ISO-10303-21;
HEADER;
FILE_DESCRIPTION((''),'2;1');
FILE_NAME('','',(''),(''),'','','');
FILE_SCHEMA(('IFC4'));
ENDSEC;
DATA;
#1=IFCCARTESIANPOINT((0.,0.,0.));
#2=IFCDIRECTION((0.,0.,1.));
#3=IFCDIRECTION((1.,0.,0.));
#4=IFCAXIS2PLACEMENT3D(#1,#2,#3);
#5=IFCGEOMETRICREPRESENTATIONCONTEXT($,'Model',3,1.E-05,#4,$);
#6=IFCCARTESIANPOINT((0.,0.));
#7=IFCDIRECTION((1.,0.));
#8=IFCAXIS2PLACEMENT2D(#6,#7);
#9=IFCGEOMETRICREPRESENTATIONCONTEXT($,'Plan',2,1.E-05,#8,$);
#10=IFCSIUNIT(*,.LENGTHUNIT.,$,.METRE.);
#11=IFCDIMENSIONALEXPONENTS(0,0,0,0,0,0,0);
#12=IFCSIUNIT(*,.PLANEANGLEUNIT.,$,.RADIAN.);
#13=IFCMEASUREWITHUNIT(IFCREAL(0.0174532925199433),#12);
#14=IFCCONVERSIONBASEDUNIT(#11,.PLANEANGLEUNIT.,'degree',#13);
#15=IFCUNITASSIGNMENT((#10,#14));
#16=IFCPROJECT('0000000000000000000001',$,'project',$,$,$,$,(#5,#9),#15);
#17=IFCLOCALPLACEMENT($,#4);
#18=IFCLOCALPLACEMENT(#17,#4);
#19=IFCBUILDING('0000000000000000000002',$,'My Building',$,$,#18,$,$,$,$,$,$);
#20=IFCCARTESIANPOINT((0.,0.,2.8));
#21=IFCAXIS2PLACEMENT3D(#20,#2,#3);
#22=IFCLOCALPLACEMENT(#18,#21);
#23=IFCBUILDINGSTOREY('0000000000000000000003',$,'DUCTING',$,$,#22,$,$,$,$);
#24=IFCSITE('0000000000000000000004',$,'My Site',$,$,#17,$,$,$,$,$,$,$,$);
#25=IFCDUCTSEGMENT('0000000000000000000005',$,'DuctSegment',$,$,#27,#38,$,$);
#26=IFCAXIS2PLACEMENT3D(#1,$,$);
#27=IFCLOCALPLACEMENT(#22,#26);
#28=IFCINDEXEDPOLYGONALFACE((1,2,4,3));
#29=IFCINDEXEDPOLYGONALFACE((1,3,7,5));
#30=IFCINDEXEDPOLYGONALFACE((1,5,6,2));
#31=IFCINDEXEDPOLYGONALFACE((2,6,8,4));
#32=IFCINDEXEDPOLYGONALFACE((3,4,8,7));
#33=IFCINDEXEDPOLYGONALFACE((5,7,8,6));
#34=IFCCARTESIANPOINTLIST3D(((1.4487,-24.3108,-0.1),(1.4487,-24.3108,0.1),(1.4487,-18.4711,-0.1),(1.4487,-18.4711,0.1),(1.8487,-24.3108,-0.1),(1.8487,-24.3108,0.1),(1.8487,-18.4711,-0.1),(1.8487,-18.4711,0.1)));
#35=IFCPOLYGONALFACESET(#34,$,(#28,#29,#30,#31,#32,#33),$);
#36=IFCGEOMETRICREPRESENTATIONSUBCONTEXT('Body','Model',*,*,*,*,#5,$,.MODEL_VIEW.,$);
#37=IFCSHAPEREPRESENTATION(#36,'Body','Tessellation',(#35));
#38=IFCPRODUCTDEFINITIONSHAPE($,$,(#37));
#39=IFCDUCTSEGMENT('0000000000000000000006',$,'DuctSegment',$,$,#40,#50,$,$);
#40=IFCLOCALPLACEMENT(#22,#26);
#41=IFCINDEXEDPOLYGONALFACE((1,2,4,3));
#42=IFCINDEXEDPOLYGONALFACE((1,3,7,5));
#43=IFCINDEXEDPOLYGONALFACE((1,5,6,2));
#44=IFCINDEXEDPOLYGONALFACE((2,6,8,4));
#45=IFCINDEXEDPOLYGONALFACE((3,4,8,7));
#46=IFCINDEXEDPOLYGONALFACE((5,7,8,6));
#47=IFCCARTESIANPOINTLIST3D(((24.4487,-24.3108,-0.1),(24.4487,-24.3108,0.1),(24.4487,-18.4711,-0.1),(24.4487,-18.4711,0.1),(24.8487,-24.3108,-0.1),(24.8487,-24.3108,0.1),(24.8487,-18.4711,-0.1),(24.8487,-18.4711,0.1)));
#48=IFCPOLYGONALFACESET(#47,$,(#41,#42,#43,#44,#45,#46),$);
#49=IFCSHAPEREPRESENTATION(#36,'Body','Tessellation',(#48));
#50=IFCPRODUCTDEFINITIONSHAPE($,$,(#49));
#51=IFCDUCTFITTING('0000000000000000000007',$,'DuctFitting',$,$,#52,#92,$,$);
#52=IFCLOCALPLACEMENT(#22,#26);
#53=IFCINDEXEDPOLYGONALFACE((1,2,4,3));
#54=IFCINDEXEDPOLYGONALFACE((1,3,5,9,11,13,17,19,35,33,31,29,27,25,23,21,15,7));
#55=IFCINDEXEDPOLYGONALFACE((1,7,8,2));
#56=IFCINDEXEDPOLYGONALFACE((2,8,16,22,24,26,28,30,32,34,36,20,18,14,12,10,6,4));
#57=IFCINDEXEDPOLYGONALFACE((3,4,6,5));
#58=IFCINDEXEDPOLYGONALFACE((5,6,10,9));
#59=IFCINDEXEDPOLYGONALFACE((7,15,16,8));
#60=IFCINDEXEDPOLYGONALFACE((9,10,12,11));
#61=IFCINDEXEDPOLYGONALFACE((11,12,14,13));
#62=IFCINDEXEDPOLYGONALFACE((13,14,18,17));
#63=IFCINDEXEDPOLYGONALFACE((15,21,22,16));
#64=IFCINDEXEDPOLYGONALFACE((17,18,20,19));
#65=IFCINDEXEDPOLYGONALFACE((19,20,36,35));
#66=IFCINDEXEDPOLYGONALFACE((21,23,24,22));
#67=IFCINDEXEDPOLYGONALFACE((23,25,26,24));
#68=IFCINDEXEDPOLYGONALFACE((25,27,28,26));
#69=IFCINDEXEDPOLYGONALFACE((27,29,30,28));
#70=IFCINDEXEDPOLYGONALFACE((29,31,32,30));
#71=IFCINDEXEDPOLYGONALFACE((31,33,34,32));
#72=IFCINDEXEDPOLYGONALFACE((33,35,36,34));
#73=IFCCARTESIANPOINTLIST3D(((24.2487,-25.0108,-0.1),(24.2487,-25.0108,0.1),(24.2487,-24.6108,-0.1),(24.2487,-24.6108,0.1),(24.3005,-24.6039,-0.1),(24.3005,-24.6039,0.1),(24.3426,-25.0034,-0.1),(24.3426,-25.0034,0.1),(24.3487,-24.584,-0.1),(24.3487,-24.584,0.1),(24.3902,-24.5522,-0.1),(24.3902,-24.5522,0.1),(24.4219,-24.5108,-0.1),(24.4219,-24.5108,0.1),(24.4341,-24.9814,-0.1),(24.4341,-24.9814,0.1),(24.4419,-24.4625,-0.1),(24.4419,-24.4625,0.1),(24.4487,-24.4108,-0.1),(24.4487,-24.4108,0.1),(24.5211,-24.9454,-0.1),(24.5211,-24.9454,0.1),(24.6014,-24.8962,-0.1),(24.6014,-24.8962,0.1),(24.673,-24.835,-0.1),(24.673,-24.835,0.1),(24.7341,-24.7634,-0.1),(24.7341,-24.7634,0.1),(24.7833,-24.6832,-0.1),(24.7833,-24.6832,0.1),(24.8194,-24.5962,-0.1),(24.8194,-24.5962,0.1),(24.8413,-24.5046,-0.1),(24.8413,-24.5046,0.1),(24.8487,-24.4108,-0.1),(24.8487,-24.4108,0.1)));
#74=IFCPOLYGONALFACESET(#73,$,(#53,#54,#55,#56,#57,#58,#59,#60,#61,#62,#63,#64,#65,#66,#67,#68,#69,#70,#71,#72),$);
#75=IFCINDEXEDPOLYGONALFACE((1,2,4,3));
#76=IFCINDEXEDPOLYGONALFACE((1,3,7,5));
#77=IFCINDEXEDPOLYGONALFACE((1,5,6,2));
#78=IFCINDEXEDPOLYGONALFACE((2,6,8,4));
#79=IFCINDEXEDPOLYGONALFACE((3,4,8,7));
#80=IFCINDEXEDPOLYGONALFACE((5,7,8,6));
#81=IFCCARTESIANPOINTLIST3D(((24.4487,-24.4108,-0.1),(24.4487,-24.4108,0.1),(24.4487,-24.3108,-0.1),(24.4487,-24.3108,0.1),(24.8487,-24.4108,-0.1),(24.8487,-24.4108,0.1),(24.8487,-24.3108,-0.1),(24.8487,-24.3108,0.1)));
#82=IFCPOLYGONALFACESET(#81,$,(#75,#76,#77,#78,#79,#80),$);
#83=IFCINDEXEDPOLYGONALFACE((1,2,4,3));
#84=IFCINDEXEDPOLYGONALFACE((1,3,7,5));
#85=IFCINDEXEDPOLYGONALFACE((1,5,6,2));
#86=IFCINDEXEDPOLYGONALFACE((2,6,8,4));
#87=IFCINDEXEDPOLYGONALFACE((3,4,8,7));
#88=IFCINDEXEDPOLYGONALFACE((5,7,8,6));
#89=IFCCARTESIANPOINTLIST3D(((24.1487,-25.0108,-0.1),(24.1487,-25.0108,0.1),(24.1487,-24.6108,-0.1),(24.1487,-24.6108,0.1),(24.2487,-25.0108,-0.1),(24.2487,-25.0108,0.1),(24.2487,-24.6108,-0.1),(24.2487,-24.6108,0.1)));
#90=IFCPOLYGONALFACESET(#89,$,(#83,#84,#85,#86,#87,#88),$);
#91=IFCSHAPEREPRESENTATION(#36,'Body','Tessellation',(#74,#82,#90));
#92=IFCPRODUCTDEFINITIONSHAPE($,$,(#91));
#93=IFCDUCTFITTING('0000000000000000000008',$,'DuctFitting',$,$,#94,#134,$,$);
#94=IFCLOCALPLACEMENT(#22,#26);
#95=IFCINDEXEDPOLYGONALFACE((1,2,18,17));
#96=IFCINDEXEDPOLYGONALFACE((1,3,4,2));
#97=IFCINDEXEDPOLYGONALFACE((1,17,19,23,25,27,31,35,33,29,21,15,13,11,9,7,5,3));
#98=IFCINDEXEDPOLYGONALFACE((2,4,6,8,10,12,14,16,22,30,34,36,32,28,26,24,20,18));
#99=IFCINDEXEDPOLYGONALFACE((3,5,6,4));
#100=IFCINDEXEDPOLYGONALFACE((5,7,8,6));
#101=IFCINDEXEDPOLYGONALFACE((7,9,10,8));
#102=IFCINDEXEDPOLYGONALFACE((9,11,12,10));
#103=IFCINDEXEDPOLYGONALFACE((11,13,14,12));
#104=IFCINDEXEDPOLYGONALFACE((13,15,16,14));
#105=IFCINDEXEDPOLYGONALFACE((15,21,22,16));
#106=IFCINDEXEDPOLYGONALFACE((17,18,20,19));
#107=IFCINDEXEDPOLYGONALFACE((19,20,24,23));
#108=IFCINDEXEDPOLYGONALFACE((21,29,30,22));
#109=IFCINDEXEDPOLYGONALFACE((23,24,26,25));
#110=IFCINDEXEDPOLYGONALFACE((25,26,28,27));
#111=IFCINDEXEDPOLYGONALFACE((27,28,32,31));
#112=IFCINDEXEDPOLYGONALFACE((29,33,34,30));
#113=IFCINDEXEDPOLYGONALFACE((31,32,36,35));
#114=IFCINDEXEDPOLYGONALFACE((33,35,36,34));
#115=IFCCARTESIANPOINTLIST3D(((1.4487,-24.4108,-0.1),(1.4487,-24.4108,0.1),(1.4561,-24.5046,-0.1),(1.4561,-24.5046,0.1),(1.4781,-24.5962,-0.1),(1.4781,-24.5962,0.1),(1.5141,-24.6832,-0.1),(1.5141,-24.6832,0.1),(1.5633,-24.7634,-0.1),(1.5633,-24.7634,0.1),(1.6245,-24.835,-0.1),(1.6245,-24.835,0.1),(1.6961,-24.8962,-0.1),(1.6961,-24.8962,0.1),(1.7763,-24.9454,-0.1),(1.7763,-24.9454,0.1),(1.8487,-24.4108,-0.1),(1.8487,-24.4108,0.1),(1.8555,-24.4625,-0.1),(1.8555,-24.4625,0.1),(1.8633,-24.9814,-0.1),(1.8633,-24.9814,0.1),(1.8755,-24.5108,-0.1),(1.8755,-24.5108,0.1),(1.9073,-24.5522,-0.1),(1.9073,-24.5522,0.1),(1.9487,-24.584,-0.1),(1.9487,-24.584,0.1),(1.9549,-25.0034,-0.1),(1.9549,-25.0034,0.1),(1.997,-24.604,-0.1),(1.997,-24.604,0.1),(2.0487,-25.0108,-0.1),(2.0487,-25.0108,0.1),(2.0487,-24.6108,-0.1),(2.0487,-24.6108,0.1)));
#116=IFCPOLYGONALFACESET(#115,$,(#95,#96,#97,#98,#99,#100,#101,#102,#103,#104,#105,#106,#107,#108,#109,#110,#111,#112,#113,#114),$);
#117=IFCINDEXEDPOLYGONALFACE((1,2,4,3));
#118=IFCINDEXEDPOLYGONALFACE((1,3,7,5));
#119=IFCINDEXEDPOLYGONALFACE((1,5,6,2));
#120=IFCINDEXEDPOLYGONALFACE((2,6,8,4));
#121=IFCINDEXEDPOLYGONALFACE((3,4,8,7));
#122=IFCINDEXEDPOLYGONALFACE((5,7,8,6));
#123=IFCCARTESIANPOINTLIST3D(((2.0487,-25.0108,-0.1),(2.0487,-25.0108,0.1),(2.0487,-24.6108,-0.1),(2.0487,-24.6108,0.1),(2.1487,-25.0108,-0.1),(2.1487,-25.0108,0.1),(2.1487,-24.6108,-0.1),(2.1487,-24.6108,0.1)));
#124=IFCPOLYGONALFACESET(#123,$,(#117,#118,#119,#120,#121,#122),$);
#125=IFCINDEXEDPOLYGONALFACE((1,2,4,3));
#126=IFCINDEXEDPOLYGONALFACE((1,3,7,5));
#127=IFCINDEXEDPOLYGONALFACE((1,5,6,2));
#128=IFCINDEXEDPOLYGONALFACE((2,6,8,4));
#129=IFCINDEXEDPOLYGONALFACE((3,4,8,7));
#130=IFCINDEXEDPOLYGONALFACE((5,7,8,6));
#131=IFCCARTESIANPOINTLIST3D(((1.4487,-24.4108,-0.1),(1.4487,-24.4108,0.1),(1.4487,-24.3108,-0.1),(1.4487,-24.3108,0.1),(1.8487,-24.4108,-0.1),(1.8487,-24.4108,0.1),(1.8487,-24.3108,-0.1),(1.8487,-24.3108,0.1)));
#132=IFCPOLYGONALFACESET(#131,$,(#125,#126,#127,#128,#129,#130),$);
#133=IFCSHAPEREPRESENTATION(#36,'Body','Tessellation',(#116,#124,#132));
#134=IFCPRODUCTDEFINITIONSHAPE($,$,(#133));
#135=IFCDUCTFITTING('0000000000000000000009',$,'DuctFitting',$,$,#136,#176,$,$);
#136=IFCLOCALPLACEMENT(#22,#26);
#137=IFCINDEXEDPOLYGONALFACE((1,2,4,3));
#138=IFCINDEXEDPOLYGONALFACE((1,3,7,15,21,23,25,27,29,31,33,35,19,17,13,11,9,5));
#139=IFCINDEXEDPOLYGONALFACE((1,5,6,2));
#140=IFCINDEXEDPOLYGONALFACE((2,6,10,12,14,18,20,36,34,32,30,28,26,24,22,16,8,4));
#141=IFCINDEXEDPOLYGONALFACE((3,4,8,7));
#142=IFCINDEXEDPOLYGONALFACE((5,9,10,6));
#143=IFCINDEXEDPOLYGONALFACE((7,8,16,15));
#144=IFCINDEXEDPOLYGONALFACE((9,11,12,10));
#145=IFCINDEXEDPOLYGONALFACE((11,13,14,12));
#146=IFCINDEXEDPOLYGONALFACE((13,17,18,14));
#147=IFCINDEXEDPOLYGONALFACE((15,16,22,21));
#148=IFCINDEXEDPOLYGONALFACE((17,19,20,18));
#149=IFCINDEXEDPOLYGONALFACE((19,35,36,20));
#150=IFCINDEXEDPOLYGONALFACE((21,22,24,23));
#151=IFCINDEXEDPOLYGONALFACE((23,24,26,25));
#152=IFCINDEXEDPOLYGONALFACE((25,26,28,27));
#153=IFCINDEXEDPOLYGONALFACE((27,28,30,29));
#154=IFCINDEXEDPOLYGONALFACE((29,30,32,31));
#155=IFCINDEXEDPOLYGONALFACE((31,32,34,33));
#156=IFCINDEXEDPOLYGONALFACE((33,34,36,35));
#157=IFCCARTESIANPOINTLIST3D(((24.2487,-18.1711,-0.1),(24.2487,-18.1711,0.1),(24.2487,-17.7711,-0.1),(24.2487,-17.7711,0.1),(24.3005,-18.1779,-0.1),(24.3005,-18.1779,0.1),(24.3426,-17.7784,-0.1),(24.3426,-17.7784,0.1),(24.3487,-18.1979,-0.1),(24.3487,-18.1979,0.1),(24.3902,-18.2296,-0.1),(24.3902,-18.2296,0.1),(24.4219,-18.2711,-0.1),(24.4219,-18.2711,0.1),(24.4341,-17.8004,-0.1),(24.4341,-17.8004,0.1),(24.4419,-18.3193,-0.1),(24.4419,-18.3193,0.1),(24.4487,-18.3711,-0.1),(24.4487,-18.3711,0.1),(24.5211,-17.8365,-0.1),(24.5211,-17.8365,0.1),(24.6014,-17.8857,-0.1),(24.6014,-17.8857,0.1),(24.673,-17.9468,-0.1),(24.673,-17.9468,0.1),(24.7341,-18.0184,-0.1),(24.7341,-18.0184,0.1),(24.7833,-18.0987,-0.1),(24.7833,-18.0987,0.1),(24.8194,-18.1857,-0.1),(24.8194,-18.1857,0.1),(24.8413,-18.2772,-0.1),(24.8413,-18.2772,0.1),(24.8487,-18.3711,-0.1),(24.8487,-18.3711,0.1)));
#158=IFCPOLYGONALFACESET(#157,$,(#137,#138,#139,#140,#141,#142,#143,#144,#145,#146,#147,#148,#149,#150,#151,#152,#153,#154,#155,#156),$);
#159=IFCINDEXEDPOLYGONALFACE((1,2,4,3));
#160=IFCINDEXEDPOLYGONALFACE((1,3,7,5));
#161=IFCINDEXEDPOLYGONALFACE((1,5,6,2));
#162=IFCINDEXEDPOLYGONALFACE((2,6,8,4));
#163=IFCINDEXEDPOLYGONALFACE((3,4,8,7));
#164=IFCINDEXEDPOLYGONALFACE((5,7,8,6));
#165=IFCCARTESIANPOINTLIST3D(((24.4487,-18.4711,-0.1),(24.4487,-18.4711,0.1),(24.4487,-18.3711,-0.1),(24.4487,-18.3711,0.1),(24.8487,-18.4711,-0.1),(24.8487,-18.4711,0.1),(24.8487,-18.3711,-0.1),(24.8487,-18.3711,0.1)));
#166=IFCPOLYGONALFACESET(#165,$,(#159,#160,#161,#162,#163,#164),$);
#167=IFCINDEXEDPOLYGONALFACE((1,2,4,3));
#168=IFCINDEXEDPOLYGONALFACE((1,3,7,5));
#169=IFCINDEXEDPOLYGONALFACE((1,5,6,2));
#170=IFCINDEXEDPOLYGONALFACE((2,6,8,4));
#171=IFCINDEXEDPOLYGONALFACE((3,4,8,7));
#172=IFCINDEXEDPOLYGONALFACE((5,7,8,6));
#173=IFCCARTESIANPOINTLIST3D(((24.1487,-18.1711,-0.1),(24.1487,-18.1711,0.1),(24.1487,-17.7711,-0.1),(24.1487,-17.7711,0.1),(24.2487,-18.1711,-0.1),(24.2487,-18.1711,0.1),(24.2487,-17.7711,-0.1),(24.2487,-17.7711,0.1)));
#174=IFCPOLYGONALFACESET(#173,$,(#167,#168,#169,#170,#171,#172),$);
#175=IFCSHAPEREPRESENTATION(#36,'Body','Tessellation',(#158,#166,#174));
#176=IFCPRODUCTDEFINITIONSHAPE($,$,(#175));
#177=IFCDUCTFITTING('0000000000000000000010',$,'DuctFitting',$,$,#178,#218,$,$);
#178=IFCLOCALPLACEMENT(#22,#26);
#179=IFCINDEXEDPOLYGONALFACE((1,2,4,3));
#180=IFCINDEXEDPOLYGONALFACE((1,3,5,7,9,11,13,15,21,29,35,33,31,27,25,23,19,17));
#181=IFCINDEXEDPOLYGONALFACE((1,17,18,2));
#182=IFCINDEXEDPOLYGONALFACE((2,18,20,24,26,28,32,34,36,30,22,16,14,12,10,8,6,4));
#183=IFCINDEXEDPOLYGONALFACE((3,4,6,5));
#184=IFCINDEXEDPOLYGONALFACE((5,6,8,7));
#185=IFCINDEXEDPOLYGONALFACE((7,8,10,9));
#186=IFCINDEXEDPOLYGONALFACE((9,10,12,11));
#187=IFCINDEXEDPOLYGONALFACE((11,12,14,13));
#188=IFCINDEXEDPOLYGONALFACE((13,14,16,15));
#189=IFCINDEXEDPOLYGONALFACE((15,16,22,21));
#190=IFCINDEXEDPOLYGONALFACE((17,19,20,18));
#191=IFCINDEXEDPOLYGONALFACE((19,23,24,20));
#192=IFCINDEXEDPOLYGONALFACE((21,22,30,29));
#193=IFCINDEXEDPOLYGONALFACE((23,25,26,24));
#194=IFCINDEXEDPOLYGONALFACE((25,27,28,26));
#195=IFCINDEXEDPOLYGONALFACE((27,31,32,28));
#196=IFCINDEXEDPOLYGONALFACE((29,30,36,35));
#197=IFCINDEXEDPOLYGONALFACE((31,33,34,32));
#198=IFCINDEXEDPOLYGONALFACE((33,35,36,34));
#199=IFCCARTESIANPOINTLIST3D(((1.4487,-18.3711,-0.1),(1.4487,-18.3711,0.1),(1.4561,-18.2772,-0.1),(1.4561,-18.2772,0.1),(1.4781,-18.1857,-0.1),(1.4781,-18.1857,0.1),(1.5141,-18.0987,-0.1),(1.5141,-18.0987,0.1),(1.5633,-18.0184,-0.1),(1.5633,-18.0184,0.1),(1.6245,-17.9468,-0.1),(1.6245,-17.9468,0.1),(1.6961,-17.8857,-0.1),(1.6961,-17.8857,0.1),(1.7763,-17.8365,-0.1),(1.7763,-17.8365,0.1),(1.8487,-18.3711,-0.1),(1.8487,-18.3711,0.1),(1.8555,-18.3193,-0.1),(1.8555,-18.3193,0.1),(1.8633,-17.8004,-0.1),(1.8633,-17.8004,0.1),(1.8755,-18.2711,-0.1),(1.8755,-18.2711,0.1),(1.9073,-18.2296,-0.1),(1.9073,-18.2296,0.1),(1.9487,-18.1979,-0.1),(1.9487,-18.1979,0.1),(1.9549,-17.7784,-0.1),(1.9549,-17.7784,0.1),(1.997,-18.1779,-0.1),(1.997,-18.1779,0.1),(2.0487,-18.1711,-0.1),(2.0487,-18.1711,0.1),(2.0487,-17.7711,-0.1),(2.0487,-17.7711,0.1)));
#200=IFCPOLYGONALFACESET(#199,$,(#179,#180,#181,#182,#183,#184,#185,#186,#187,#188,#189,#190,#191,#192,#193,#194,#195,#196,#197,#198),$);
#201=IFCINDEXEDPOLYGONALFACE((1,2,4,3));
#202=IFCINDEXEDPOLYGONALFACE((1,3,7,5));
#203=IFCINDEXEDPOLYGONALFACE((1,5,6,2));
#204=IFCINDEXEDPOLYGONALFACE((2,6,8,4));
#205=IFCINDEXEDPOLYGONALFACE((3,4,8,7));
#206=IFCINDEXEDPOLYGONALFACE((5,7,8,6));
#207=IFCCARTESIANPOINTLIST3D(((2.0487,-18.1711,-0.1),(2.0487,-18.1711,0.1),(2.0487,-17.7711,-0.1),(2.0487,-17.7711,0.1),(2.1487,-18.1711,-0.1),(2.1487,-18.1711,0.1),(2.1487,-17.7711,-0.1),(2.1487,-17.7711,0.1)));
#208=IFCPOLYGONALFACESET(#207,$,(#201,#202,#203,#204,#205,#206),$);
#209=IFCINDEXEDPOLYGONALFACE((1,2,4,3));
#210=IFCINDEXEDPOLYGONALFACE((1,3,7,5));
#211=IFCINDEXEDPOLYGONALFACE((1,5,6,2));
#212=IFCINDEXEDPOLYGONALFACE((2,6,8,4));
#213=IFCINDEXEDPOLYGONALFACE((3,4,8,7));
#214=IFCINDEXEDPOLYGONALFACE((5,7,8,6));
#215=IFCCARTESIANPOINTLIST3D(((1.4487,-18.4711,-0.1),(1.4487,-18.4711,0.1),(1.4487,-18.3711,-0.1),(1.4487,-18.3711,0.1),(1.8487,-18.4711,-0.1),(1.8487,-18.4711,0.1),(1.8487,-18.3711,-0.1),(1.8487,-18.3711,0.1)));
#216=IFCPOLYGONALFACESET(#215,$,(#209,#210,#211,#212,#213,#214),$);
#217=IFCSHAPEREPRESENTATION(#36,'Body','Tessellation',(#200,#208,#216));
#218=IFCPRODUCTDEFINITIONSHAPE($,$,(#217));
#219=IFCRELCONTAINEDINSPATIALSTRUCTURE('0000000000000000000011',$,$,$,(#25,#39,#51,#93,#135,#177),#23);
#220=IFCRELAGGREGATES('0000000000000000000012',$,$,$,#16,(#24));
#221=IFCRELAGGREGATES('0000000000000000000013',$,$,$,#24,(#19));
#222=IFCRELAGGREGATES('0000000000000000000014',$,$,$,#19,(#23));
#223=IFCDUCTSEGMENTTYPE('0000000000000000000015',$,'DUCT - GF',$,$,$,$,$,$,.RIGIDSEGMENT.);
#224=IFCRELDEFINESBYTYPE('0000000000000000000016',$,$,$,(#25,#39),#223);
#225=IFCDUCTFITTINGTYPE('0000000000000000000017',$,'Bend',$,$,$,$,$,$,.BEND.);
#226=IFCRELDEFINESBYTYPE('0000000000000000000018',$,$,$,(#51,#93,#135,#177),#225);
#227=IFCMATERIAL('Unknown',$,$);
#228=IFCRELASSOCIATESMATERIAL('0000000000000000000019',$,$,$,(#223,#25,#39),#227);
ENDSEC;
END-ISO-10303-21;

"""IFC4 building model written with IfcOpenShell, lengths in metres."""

from ifc_helpers import new_model, entity, si_unit, converted_unit, frame, origin_with_axes, origin_2d_with_axis, place, context, subcontext, project, spatial, line, arc, indexed_curve, rectangle, outline, extrude, source, transform, mapped, material, material_profile, profile_set, profile_usage, type_object, type_shapes, element, save


model = new_model("IFC4")

# Units and contexts
model_context = context("Model", 3, precision=1e-05, world=origin_with_axes())
plan_context = context("Plan", 2, precision=1e-05, world=origin_2d_with_axis())
body_context = subcontext(model_context, "Body", "Model", "MODEL_VIEW")
ifc_project = project(units=[si_unit("LENGTHUNIT", "METRE"), converted_unit("PLANEANGLEUNIT", "degree", entity("IfcReal", 0.0174532925199433), si_unit("PLANEANGLEUNIT", "RADIAN"), dimensions=[0, 0, 0, 0, 0, 0, 0])], contexts=[model_context, plan_context])

# Site, building, storey
site_placement = place(None, origin_with_axes())
site = spatial("IfcSite", under=ifc_project, at=site_placement, Name="My Site")
building_placement = place(site_placement, origin_with_axes())
building = spatial("IfcBuilding", under=site, at=building_placement, Name="My Building")
storey_placement = place(building_placement, frame((0.0, 0.0, 2.8), z_axis=(0.0, 0.0, 1.0), x_axis=(1.0, 0.0, 0.0)))
storey = spatial("IfcBuildingStorey", under=building, at=storey_placement, Name="DUCTING")

# Duct segments
ifc_material = material(Name="Unknown")
ifc_material_profile = material_profile(ifc_material, rectangle(XDim=0.4, YDim=0.2))
ifc_profile_set = profile_set([ifc_material_profile])
ifc_profile_usage_1 = profile_usage(ifc_profile_set, cardinal=5)
duct_segment_type = type_object("IfcDuctSegmentType", Name="DUCT - GF", PredefinedType="RIGIDSEGMENT", material=ifc_profile_set)
duct_segment_1_placement = place(storey_placement, frame((1.6487, -18.4711, 0.0), z_axis=(0.0, -1.0, 0.0), x_axis=(1.0, 0.0, 0.0)))
element("IfcDuctSegment", 1, at=duct_segment_1_placement, inside=storey, type_object=duct_segment_type, material=ifc_profile_usage_1, Name="DuctSegment", context=body_context, shape_type="SweptSolid", body=[
    extrude(rectangle(XDim=0.4, YDim=0.2), origin_with_axes(), (0.0, 0.0, 1.0), 5.8397),
])
ifc_profile_usage_2 = profile_usage(ifc_profile_set, cardinal=5)
duct_segment_2_placement = place(storey_placement, frame((24.6487, -18.4711, 0.0), z_axis=(0.0, -1.0, 0.0), x_axis=(1.0, 0.0, 0.0)))
element("IfcDuctSegment", 2, at=duct_segment_2_placement, inside=storey, type_object=duct_segment_type, material=ifc_profile_usage_2, Name="DuctSegment", context=body_context, shape_type="SweptSolid", body=[
    extrude(rectangle(XDim=0.4, YDim=0.2), origin_with_axes(), (0.0, 0.0, 1.0), 5.8397),
])

# Duct fittings
duct_fitting_type = type_object("IfcDuctFittingType", Name="Bend", PredefinedType="BEND")
shared_shape = source(origin_with_axes(), body_context, "Body", "SweptSolid", [
    extrude(outline(indexed_curve([(-0.2, 0.0), (-0.2586, 0.1414), (-0.4, 0.2), (-0.4, 0.6), (0.0243, 0.4243), (0.2, 0.0)], segments=[arc(1, 2, 3), line(3, 4), arc(4, 5, 6), line(6, 1)])), frame((0.0, -0.1, 0.1), z_axis=(0.0, -1.0, 0.0), x_axis=(1.0, 0.0, 0.0)), (0.0, 0.0, -1.0), 0.2),
    extrude(rectangle(XDim=0.4, YDim=0.2), origin_with_axes(), (0.0, 0.0, 1.0), 0.1),
    extrude(rectangle(XDim=0.4, YDim=0.2), frame((-0.4, 0.0, 0.5), z_axis=(-1.0, 0.0, 0.0), x_axis=(0.0, 0.0, -1.0)), (0.0, 0.0, 1.0), 0.1),
])
type_shapes(duct_fitting_type, [shared_shape])
for number, where, z_axis, x_axis, name in (
    (3, (24.6487, -24.3108, 0.0), (0.0, -1.0, 0.0), (1.0, 0.0, 0.0), "DuctFitting"),
    (4, (2.1487, -24.8108, 0.0), (-1.0, 0.0, 0.0), (0.0, -1.0, 0.0), "DuctFitting"),
    (5, (24.6487, -18.4711, 0.0), (0.0, 1.0, 0.0), (1.0, 0.0, 0.0), "DuctFitting"),
    (6, (2.1487, -17.9711, 0.0), (-1.0, 0.0, 0.0), (0.0, 1.0, 0.0), "DuctFitting"),
):
    element("IfcDuctFitting", number, at=place(storey_placement, frame(where, z_axis=z_axis, x_axis=x_axis)), inside=storey, type_object=duct_fitting_type, Name=name, context=body_context, shape_type="MappedRepresentation", body=[
        mapped(shared_shape, transform((0.0, 0.0, 0.0), x_axis=(1.0, 0.0, 0.0), y_axis=(0.0, 1.0, 0.0), z_axis=(0.0, 0.0, 1.0), scale=1.0)),
    ])

save(model, "model.ifc")
